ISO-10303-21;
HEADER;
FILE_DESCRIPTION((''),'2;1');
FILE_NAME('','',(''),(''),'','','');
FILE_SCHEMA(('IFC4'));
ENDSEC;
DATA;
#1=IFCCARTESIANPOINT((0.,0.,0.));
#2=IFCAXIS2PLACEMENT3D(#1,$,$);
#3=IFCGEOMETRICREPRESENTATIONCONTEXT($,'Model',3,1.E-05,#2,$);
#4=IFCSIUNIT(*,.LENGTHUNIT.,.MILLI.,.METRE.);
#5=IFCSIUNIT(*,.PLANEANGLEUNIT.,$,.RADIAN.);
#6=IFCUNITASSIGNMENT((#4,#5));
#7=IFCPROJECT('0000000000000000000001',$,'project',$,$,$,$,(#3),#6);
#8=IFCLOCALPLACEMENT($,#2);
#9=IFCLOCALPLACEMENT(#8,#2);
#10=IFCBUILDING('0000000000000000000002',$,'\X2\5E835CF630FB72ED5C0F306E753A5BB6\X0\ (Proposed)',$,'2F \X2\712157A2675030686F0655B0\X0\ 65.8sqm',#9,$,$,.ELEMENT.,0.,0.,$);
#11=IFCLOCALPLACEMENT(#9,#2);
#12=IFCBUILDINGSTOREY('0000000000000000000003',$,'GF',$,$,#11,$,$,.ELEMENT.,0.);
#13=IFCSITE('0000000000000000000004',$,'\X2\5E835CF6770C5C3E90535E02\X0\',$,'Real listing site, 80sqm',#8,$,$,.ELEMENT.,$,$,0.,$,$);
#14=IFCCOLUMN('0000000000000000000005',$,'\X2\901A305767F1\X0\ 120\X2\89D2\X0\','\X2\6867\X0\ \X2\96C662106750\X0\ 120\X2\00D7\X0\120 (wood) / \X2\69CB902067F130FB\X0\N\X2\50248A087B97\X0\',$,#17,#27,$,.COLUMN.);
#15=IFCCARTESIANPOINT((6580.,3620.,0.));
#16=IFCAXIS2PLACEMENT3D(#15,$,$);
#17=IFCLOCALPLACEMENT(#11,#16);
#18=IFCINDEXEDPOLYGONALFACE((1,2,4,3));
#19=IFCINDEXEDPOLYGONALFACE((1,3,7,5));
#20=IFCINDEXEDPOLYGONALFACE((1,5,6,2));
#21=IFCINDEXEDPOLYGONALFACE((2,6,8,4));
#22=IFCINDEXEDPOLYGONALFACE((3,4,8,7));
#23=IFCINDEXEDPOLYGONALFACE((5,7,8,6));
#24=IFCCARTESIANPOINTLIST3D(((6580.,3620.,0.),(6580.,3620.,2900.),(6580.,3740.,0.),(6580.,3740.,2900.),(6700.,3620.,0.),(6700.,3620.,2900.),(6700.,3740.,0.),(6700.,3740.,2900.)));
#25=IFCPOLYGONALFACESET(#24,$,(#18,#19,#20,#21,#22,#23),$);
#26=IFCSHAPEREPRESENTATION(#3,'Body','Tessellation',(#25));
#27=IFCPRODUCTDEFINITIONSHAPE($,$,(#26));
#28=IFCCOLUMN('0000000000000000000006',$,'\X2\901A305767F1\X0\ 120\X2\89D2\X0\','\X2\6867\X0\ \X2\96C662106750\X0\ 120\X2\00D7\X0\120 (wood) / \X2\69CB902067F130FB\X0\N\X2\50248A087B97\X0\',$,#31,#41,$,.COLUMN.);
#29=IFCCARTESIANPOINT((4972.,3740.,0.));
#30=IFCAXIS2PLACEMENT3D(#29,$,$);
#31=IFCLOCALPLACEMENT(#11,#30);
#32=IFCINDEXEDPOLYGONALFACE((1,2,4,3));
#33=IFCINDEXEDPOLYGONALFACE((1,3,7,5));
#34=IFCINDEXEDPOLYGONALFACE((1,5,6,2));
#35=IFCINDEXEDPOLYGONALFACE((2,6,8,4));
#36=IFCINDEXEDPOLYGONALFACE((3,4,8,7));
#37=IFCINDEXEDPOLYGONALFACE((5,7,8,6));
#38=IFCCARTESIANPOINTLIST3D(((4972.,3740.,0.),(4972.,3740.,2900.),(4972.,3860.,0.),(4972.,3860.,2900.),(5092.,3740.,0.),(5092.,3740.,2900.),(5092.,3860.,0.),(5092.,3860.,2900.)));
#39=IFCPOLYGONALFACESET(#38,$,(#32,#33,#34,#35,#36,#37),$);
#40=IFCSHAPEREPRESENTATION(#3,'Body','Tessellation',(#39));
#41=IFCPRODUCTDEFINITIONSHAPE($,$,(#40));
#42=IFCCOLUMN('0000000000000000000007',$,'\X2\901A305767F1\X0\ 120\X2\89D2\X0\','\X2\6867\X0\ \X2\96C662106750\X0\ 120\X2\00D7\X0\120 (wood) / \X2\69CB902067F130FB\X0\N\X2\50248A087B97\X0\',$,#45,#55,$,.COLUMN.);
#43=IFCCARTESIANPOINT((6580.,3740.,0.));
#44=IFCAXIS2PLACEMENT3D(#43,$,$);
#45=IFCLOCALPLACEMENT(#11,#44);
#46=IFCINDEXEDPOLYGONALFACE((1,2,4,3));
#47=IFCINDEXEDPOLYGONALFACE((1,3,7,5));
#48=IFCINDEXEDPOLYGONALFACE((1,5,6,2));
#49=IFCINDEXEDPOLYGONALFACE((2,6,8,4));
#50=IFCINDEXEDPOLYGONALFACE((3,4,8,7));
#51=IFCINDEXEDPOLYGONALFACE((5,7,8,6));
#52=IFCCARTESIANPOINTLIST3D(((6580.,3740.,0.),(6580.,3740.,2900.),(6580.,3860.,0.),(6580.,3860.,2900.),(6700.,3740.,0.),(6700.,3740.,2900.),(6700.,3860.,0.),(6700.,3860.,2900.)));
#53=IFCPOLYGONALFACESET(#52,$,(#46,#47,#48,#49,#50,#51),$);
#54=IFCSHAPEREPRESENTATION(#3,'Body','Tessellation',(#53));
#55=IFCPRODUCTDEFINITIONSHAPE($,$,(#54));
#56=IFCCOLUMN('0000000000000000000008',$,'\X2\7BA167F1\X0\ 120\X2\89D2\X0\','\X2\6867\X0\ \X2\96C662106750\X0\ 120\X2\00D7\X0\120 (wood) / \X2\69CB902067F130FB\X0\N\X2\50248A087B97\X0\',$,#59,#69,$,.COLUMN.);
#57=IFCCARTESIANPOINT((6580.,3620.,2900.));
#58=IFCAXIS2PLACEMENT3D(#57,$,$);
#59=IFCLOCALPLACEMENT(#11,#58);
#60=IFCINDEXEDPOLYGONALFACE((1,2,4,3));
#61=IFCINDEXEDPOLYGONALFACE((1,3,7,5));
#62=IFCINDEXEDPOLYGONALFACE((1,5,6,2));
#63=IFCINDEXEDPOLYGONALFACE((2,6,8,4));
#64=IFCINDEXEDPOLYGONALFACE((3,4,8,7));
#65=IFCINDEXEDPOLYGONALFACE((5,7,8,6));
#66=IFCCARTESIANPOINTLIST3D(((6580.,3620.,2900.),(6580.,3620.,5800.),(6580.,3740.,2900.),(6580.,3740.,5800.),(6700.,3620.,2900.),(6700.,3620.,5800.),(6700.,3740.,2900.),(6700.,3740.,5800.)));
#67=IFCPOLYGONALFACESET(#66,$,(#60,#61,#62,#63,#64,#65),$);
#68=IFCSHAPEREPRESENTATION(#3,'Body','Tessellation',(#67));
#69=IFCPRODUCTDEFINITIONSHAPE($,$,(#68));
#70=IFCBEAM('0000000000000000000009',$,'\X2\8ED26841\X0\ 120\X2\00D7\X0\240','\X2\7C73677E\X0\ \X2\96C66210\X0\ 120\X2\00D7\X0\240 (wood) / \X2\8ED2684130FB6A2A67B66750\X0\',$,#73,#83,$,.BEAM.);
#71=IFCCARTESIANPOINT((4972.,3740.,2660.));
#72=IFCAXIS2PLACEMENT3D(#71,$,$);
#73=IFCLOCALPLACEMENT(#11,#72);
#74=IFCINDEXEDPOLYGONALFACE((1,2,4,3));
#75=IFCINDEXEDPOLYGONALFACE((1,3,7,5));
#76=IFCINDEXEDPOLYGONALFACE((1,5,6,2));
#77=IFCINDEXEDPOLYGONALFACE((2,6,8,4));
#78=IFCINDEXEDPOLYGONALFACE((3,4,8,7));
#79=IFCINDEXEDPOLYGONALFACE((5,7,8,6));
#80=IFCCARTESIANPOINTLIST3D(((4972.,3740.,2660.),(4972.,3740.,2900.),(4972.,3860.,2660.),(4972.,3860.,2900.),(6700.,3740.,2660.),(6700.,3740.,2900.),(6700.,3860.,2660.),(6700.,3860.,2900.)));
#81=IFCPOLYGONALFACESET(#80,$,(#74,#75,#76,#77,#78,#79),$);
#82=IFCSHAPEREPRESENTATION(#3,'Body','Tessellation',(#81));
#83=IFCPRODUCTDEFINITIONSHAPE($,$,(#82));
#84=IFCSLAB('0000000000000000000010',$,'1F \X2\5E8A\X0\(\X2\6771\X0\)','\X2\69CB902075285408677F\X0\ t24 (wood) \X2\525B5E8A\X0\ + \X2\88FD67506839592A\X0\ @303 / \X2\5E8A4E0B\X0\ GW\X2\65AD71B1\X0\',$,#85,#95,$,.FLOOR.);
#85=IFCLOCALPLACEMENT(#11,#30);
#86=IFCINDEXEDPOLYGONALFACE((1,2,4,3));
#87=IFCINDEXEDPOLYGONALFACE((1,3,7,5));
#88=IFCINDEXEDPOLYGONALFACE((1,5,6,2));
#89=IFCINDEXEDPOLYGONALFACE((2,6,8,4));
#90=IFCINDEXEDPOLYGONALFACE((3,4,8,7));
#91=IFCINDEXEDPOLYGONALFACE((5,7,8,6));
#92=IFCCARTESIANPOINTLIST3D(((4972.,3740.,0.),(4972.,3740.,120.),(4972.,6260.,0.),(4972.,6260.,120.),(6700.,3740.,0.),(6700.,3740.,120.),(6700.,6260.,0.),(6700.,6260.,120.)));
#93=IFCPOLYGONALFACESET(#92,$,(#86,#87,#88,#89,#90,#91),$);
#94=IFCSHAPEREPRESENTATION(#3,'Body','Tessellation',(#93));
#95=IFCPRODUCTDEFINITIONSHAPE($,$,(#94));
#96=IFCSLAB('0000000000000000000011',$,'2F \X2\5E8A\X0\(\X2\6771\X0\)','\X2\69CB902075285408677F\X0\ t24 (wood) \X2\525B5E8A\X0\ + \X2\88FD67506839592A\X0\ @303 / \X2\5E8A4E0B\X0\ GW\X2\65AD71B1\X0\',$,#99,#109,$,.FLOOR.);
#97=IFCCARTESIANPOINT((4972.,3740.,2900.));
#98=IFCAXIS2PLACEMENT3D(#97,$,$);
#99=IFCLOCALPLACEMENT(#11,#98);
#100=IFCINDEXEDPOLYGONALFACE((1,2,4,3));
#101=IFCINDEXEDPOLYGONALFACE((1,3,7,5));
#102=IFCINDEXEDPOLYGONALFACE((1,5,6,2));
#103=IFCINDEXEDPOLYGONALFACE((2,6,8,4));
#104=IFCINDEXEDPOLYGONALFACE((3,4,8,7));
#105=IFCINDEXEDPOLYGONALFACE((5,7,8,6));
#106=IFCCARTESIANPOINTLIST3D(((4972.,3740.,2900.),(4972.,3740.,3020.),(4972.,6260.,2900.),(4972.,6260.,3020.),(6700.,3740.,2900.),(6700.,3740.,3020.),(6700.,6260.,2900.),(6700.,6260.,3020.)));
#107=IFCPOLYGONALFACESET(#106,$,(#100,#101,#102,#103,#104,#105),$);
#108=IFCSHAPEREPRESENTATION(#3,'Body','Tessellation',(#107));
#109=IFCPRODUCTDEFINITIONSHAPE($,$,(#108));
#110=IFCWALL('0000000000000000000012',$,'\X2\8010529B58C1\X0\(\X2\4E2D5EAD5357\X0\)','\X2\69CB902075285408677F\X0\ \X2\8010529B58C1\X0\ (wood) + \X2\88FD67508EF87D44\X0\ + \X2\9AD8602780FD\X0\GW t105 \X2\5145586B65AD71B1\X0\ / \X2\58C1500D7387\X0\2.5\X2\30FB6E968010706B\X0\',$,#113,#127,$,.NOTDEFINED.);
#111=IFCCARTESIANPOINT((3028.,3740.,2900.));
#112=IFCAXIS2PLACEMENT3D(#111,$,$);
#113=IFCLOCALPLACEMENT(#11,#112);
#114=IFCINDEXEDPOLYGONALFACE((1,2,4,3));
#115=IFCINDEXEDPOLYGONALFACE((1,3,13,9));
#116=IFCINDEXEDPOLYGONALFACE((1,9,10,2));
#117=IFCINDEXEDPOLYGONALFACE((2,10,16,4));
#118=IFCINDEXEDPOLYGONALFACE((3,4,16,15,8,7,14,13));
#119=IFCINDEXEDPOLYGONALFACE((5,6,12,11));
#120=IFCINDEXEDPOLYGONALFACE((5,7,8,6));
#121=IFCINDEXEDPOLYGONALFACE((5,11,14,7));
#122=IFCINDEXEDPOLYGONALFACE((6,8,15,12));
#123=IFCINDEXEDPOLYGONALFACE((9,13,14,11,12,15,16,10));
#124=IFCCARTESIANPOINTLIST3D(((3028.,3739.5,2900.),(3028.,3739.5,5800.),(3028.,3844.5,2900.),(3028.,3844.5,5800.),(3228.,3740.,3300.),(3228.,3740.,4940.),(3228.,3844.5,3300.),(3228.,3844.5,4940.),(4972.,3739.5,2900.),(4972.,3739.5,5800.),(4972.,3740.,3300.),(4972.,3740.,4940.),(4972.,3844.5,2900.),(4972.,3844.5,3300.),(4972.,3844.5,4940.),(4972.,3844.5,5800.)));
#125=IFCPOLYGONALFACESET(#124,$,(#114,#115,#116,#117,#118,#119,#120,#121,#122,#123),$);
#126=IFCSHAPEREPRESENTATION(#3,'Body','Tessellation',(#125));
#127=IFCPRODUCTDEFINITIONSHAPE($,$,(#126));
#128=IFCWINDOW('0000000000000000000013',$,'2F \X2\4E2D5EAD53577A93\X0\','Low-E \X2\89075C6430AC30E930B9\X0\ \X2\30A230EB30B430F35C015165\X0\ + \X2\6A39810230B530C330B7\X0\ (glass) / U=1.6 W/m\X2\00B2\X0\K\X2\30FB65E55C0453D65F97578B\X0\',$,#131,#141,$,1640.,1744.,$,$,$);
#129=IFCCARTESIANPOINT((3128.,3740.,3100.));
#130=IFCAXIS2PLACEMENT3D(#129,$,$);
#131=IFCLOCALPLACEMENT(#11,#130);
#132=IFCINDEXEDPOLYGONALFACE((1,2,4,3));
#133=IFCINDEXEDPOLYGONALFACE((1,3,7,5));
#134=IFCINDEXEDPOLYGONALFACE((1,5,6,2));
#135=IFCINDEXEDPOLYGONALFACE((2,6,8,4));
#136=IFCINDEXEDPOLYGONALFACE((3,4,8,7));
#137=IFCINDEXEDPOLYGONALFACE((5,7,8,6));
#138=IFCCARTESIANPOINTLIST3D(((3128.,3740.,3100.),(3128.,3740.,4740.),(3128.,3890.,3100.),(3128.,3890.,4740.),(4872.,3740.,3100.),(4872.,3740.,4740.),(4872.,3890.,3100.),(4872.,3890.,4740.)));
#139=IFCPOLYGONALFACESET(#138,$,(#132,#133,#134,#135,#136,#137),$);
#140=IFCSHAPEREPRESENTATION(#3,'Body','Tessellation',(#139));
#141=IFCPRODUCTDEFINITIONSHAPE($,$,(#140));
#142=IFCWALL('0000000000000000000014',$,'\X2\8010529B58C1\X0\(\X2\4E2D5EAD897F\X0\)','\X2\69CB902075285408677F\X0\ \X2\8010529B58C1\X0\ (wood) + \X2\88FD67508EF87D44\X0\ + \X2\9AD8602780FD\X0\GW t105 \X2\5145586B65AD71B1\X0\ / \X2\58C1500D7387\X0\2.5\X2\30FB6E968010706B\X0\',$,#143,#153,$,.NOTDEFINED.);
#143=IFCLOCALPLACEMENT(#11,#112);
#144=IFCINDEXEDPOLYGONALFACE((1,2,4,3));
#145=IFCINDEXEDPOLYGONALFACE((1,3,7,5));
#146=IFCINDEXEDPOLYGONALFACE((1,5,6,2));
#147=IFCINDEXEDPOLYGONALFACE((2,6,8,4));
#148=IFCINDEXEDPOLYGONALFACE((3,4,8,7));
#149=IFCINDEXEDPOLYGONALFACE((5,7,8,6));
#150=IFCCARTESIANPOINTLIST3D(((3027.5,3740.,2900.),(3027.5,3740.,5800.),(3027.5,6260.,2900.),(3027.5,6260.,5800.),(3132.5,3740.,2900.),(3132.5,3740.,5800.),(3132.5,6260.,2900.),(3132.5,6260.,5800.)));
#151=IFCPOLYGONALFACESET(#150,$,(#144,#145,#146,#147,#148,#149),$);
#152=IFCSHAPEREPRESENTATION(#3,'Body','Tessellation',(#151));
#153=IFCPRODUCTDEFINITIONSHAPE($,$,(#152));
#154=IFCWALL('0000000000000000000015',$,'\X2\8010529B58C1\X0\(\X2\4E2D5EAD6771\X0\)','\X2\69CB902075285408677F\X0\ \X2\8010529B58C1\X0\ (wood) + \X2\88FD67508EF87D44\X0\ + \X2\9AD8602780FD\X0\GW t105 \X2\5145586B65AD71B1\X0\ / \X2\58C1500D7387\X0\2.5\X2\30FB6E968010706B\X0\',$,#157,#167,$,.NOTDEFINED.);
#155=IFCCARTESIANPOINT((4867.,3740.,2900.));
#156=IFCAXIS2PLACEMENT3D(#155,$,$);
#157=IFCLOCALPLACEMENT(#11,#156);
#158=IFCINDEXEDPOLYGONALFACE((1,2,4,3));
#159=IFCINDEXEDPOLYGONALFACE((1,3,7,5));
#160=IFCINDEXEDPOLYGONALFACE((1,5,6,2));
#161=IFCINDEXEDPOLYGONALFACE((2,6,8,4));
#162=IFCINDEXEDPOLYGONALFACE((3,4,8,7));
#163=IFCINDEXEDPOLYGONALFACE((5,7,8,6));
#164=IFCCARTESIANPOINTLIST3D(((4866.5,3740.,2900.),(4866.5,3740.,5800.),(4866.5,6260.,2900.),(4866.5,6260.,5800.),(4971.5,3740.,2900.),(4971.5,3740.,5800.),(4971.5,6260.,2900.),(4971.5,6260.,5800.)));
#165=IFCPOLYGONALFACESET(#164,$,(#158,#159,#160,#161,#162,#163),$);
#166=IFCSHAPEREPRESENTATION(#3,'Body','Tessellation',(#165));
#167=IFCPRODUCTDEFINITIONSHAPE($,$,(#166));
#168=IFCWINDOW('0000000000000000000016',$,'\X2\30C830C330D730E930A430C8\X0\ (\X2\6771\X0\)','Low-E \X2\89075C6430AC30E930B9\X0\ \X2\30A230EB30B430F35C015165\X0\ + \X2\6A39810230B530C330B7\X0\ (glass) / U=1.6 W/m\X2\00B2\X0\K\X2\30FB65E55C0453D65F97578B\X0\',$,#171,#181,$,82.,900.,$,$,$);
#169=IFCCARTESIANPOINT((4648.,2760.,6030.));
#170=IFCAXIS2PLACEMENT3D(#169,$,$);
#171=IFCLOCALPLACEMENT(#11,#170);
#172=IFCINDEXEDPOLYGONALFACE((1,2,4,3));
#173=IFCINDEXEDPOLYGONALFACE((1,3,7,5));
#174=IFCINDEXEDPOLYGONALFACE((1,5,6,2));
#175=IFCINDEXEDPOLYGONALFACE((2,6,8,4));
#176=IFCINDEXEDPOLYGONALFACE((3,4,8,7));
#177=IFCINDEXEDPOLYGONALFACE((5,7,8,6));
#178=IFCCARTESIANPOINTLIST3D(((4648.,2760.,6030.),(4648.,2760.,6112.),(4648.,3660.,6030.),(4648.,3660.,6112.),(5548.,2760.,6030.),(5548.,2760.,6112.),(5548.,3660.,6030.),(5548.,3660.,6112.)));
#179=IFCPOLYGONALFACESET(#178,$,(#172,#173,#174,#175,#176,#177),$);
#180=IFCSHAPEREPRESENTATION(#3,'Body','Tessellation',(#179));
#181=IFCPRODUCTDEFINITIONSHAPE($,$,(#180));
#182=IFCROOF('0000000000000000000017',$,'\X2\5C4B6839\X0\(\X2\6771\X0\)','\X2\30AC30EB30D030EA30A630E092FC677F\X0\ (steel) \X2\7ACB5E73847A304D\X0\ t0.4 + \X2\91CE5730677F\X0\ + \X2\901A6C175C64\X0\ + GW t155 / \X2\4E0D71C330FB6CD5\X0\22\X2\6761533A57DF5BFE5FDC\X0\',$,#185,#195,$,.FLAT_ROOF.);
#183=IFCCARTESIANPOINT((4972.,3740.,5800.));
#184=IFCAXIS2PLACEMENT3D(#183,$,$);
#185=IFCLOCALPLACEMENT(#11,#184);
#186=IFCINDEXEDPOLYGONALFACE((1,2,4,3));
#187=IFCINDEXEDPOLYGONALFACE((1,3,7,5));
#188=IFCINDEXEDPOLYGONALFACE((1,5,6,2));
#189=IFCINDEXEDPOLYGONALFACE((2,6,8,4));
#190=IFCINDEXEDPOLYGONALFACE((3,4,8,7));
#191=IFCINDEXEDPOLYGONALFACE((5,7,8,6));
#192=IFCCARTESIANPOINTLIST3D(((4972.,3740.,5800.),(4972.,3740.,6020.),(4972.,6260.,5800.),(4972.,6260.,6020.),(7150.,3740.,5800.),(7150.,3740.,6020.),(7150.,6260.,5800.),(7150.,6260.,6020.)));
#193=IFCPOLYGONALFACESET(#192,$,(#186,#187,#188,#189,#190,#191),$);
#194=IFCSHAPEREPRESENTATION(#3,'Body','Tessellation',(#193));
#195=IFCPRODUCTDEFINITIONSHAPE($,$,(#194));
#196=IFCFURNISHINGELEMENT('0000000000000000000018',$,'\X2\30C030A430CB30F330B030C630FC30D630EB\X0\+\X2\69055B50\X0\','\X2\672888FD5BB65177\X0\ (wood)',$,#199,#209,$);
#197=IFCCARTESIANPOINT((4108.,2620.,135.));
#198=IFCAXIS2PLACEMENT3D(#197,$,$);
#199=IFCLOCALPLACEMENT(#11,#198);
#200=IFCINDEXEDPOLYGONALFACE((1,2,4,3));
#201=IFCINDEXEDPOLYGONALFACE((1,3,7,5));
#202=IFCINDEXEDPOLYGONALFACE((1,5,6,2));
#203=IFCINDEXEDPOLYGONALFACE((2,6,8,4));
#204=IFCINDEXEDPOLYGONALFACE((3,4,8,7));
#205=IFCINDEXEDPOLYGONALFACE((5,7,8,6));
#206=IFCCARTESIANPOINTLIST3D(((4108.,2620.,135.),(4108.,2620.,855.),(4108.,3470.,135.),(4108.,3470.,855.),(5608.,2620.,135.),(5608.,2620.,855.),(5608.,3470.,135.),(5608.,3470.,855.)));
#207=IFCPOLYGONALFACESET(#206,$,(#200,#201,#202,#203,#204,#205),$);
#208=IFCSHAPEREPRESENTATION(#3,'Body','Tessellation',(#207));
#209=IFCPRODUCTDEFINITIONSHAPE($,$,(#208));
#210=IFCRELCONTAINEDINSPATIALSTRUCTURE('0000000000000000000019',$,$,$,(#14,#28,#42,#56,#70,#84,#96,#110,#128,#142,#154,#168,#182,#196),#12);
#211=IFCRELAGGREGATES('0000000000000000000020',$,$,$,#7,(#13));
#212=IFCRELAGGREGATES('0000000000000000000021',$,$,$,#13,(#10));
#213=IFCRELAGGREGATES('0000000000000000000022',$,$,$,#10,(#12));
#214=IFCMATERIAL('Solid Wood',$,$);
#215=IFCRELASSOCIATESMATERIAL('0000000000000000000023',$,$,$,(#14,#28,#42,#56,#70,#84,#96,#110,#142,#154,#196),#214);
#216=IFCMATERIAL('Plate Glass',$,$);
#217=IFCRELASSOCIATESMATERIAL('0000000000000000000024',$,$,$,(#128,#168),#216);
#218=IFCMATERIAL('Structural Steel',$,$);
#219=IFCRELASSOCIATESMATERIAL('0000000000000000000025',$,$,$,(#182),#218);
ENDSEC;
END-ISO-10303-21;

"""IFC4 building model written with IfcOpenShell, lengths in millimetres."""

from ifc_helpers import new_model, si_unit, frame, frame_2d, origin, place, context, project, spatial, rectangle, extrude, material, element, fill, save


model = new_model("IFC4")

# Units and contexts
model_context = context("Model", 3, precision=1e-05, world=origin())
ifc_project = project(units=[si_unit("LENGTHUNIT", "METRE", prefix="MILLI"), si_unit("PLANEANGLEUNIT", "RADIAN")], contexts=[model_context])

# Site, building, storey
site_placement = place(None, origin())
site = spatial("IfcSite", under=ifc_project, at=site_placement, Name="広島県尾道市", ObjectType="Real listing site, 80sqm", CompositionType="ELEMENT", RefElevation=0.0)
building_placement = place(site_placement, origin())
building = spatial("IfcBuilding", under=site, at=building_placement, Name="広島・狭小の町家 (Proposed)", ObjectType="2F 無垢材と漆喰 65.8sqm", CompositionType="ELEMENT", ElevationOfRefHeight=0.0, ElevationOfTerrain=0.0)
storey_placement = place(building_placement, origin())
storey = spatial("IfcBuildingStorey", under=building, at=storey_placement, Name="GF", CompositionType="ELEMENT", Elevation=0.0)

# Columns
ifc_material_1 = material(Name="Solid Wood")
column_1_placement = place(storey_placement, frame((6580.0, 3620.0, 0.0)))
element("IfcColumn", 1, at=column_1_placement, inside=storey, material=ifc_material_1, Name="通し柱 120角", Description="桧 集成材 120×120 (wood) / 構造柱・N値計算", PredefinedType="COLUMN", context=model_context, shape_type="SweptSolid", body=[
    extrude(rectangle(XDim=120.0, YDim=120.0, at=frame_2d((60.0, 60.0))), frame((6580.0, 3620.0, 0.0)), (0.0, 0.0, 1.0), 2900.0),
])
column_2_placement = place(storey_placement, frame((4972.0, 3740.0, 0.0)))
element("IfcColumn", 2, at=column_2_placement, inside=storey, material=ifc_material_1, Name="通し柱 120角", Description="桧 集成材 120×120 (wood) / 構造柱・N値計算", PredefinedType="COLUMN", context=model_context, shape_type="SweptSolid", body=[
    extrude(rectangle(XDim=120.0, YDim=120.0, at=frame_2d((60.0, 60.0))), frame((4972.0, 3740.0, 0.0)), (0.0, 0.0, 1.0), 2900.0),
])
column_3_placement = place(storey_placement, frame((6580.0, 3740.0, 0.0)))
element("IfcColumn", 3, at=column_3_placement, inside=storey, material=ifc_material_1, Name="通し柱 120角", Description="桧 集成材 120×120 (wood) / 構造柱・N値計算", PredefinedType="COLUMN", context=model_context, shape_type="SweptSolid", body=[
    extrude(rectangle(XDim=120.0, YDim=120.0, at=frame_2d((60.0, 60.0))), frame((6580.0, 3740.0, 0.0)), (0.0, 0.0, 1.0), 2900.0),
])
column_4_placement = place(storey_placement, frame((6580.0, 3620.0, 2900.0)))
element("IfcColumn", 4, at=column_4_placement, inside=storey, material=ifc_material_1, Name="管柱 120角", Description="桧 集成材 120×120 (wood) / 構造柱・N値計算", PredefinedType="COLUMN", context=model_context, shape_type="SweptSolid", body=[
    extrude(rectangle(XDim=120.0, YDim=120.0, at=frame_2d((60.0, 60.0))), frame((6580.0, 3620.0, 2900.0)), (0.0, 0.0, 1.0), 2900.0),
])

# Beam
beam_1_placement = place(storey_placement, frame((4972.0, 3740.0, 2660.0)))
element("IfcBeam", 5, at=beam_1_placement, inside=storey, material=ifc_material_1, Name="軒桁 120×240", Description="米松 集成 120×240 (wood) / 軒桁・横架材", PredefinedType="BEAM", context=model_context, shape_type="SweptSolid", body=[
    extrude(rectangle(XDim=1728.0, YDim=120.0, at=frame_2d((864.0, 60.0))), frame((4972.0, 3740.0, 2660.0)), (0.0, 0.0, 1.0), 240.0),
])

# Slabs
slab_1_placement = place(storey_placement, frame((4972.0, 3740.0, 0.0)))
element("IfcSlab", 6, at=slab_1_placement, inside=storey, material=ifc_material_1, Name="1F 床(東)", Description="構造用合板 t24 (wood) 剛床 + 製材根太 @303 / 床下 GW断熱", PredefinedType="FLOOR", context=model_context, shape_type="SweptSolid", body=[
    extrude(rectangle(XDim=1728.0, YDim=2520.0, at=frame_2d((864.0, 1260.0))), frame((4972.0, 3740.0, 0.0)), (0.0, 0.0, 1.0), 120.0),
])
slab_2_placement = place(storey_placement, frame((4972.0, 3740.0, 2900.0)))
element("IfcSlab", 7, at=slab_2_placement, inside=storey, material=ifc_material_1, Name="2F 床(東)", Description="構造用合板 t24 (wood) 剛床 + 製材根太 @303 / 床下 GW断熱", PredefinedType="FLOOR", context=model_context, shape_type="SweptSolid", body=[
    extrude(rectangle(XDim=1728.0, YDim=2520.0, at=frame_2d((864.0, 1260.0))), frame((4972.0, 3740.0, 2900.0)), (0.0, 0.0, 1.0), 120.0),
])

# Wall, opening, window
wall_1_placement = place(storey_placement, frame((3028.0, 3740.0, 2900.0)))
wall_1 = element("IfcWall", 8, at=wall_1_placement, inside=storey, material=ifc_material_1, Name="耐力壁(中庭南)", Description="構造用合板 耐力壁 (wood) + 製材軸組 + 高性能GW t105 充填断熱 / 壁倍率2.5・準耐火", PredefinedType="NOTDEFINED", context=model_context, shape_type="SweptSolid", body=[
    extrude(rectangle(XDim=1944.0, YDim=105.0, at=frame_2d((972.0, 52.0))), frame((3028.0, 3740.0, 2900.0)), (0.0, 0.0, 1.0), 2900.0),
])
opening_placement = place(storey_placement, frame((3128.0, 3740.0, 3100.0)))
opening = element("IfcOpeningElement", 9, at=opening_placement, cuts=wall_1, PredefinedType="NOTDEFINED", context=model_context, shape_type="SweptSolid", body=[
    extrude(rectangle(XDim=1744.0, YDim=150.0, at=frame_2d((872.0, 75.0))), frame((3128.0, 3740.0, 3100.0)), (0.0, 0.0, 1.0), 1640.0),
])
ifc_material_2 = material(Name="Plate Glass")
window_1_placement = place(storey_placement, frame((3128.0, 3740.0, 3100.0)))
window_1 = element("IfcWindow", 10, at=window_1_placement, inside=storey, material=ifc_material_2, Name="2F 中庭南窓", Description="Low-E 複層ガラス アルゴン封入 + 樹脂サッシ (glass) / U=1.6 W/m²K・日射取得型", OverallHeight=1640.0, OverallWidth=1744.0, context=model_context, shape_type="SweptSolid", body=[
    extrude(rectangle(XDim=1744.0, YDim=150.0, at=frame_2d((872.0, 75.0))), frame((3128.0, 3740.0, 3100.0)), (0.0, 0.0, 1.0), 1640.0),
])
fill(opening, window_1)

# Walls
wall_2_placement = place(storey_placement, frame((3028.0, 3740.0, 2900.0)))
element("IfcWall", 11, at=wall_2_placement, inside=storey, material=ifc_material_1, Name="耐力壁(中庭西)", Description="構造用合板 耐力壁 (wood) + 製材軸組 + 高性能GW t105 充填断熱 / 壁倍率2.5・準耐火", PredefinedType="NOTDEFINED", context=model_context, shape_type="SweptSolid", body=[
    extrude(rectangle(XDim=105.0, YDim=2520.0, at=frame_2d((52.0, 1260.0))), frame((3028.0, 3740.0, 2900.0)), (0.0, 0.0, 1.0), 2900.0),
])
wall_3_placement = place(storey_placement, frame((4867.0, 3740.0, 2900.0)))
element("IfcWall", 12, at=wall_3_placement, inside=storey, material=ifc_material_1, Name="耐力壁(中庭東)", Description="構造用合板 耐力壁 (wood) + 製材軸組 + 高性能GW t105 充填断熱 / 壁倍率2.5・準耐火", PredefinedType="NOTDEFINED", context=model_context, shape_type="SweptSolid", body=[
    extrude(rectangle(XDim=105.0, YDim=2520.0, at=frame_2d((52.0, 1260.0))), frame((4867.0, 3740.0, 2900.0)), (0.0, 0.0, 1.0), 2900.0),
])

# Window
window_2_placement = place(storey_placement, frame((4648.0, 2760.0, 6030.0)))
element("IfcWindow", 13, at=window_2_placement, inside=storey, material=ifc_material_2, Name="トップライト (東)", Description="Low-E 複層ガラス アルゴン封入 + 樹脂サッシ (glass) / U=1.6 W/m²K・日射取得型", OverallHeight=82.0, OverallWidth=900.0, context=model_context, shape_type="SweptSolid", body=[
    extrude(rectangle(XDim=900.0, YDim=900.0, at=frame_2d((450.0, 450.0))), frame((4648.0, 2760.0, 6030.0)), (0.0, 0.0, 1.0), 82.0),
])

# Roof
ifc_material_3 = material(Name="Structural Steel")
for number, where, name in (
    (14, (4972.0, 3740.0, 5800.0), "屋根(東)"),
):
    element("IfcRoof", number, at=place(storey_placement, frame(where)), inside=storey, material=ifc_material_3, Name=name, Description="ガルバリウム鋼板 (steel) 立平葺き t0.4 + 野地板 + 通気層 + GW t155 / 不燃・法22条区域対応", PredefinedType="FLAT_ROOF", context=model_context, shape_type="SweptSolid", body=[
        extrude(rectangle(XDim=2178.0, YDim=2520.0, at=frame_2d((1089.0, 1260.0))), frame((4972.0, 3740.0, 5800.0)), (0.0, 0.0, 1.0), 220.0),
    ])

# Furnishing element
furnishing_1_placement = place(storey_placement, frame((4108.0, 2620.0, 135.0)))
element("IfcFurnishingElement", 15, at=furnishing_1_placement, inside=storey, material=ifc_material_1, Name="ダイニングテーブル+椅子", Description="木製家具 (wood)", context=model_context, shape_type="SweptSolid", body=[
    extrude(rectangle(XDim=1500.0, YDim=850.0, at=frame_2d((750.0, 425.0))), frame((4108.0, 2620.0, 135.0)), (0.0, 0.0, 1.0), 720.0),
])

save(model, "model.ifc")
